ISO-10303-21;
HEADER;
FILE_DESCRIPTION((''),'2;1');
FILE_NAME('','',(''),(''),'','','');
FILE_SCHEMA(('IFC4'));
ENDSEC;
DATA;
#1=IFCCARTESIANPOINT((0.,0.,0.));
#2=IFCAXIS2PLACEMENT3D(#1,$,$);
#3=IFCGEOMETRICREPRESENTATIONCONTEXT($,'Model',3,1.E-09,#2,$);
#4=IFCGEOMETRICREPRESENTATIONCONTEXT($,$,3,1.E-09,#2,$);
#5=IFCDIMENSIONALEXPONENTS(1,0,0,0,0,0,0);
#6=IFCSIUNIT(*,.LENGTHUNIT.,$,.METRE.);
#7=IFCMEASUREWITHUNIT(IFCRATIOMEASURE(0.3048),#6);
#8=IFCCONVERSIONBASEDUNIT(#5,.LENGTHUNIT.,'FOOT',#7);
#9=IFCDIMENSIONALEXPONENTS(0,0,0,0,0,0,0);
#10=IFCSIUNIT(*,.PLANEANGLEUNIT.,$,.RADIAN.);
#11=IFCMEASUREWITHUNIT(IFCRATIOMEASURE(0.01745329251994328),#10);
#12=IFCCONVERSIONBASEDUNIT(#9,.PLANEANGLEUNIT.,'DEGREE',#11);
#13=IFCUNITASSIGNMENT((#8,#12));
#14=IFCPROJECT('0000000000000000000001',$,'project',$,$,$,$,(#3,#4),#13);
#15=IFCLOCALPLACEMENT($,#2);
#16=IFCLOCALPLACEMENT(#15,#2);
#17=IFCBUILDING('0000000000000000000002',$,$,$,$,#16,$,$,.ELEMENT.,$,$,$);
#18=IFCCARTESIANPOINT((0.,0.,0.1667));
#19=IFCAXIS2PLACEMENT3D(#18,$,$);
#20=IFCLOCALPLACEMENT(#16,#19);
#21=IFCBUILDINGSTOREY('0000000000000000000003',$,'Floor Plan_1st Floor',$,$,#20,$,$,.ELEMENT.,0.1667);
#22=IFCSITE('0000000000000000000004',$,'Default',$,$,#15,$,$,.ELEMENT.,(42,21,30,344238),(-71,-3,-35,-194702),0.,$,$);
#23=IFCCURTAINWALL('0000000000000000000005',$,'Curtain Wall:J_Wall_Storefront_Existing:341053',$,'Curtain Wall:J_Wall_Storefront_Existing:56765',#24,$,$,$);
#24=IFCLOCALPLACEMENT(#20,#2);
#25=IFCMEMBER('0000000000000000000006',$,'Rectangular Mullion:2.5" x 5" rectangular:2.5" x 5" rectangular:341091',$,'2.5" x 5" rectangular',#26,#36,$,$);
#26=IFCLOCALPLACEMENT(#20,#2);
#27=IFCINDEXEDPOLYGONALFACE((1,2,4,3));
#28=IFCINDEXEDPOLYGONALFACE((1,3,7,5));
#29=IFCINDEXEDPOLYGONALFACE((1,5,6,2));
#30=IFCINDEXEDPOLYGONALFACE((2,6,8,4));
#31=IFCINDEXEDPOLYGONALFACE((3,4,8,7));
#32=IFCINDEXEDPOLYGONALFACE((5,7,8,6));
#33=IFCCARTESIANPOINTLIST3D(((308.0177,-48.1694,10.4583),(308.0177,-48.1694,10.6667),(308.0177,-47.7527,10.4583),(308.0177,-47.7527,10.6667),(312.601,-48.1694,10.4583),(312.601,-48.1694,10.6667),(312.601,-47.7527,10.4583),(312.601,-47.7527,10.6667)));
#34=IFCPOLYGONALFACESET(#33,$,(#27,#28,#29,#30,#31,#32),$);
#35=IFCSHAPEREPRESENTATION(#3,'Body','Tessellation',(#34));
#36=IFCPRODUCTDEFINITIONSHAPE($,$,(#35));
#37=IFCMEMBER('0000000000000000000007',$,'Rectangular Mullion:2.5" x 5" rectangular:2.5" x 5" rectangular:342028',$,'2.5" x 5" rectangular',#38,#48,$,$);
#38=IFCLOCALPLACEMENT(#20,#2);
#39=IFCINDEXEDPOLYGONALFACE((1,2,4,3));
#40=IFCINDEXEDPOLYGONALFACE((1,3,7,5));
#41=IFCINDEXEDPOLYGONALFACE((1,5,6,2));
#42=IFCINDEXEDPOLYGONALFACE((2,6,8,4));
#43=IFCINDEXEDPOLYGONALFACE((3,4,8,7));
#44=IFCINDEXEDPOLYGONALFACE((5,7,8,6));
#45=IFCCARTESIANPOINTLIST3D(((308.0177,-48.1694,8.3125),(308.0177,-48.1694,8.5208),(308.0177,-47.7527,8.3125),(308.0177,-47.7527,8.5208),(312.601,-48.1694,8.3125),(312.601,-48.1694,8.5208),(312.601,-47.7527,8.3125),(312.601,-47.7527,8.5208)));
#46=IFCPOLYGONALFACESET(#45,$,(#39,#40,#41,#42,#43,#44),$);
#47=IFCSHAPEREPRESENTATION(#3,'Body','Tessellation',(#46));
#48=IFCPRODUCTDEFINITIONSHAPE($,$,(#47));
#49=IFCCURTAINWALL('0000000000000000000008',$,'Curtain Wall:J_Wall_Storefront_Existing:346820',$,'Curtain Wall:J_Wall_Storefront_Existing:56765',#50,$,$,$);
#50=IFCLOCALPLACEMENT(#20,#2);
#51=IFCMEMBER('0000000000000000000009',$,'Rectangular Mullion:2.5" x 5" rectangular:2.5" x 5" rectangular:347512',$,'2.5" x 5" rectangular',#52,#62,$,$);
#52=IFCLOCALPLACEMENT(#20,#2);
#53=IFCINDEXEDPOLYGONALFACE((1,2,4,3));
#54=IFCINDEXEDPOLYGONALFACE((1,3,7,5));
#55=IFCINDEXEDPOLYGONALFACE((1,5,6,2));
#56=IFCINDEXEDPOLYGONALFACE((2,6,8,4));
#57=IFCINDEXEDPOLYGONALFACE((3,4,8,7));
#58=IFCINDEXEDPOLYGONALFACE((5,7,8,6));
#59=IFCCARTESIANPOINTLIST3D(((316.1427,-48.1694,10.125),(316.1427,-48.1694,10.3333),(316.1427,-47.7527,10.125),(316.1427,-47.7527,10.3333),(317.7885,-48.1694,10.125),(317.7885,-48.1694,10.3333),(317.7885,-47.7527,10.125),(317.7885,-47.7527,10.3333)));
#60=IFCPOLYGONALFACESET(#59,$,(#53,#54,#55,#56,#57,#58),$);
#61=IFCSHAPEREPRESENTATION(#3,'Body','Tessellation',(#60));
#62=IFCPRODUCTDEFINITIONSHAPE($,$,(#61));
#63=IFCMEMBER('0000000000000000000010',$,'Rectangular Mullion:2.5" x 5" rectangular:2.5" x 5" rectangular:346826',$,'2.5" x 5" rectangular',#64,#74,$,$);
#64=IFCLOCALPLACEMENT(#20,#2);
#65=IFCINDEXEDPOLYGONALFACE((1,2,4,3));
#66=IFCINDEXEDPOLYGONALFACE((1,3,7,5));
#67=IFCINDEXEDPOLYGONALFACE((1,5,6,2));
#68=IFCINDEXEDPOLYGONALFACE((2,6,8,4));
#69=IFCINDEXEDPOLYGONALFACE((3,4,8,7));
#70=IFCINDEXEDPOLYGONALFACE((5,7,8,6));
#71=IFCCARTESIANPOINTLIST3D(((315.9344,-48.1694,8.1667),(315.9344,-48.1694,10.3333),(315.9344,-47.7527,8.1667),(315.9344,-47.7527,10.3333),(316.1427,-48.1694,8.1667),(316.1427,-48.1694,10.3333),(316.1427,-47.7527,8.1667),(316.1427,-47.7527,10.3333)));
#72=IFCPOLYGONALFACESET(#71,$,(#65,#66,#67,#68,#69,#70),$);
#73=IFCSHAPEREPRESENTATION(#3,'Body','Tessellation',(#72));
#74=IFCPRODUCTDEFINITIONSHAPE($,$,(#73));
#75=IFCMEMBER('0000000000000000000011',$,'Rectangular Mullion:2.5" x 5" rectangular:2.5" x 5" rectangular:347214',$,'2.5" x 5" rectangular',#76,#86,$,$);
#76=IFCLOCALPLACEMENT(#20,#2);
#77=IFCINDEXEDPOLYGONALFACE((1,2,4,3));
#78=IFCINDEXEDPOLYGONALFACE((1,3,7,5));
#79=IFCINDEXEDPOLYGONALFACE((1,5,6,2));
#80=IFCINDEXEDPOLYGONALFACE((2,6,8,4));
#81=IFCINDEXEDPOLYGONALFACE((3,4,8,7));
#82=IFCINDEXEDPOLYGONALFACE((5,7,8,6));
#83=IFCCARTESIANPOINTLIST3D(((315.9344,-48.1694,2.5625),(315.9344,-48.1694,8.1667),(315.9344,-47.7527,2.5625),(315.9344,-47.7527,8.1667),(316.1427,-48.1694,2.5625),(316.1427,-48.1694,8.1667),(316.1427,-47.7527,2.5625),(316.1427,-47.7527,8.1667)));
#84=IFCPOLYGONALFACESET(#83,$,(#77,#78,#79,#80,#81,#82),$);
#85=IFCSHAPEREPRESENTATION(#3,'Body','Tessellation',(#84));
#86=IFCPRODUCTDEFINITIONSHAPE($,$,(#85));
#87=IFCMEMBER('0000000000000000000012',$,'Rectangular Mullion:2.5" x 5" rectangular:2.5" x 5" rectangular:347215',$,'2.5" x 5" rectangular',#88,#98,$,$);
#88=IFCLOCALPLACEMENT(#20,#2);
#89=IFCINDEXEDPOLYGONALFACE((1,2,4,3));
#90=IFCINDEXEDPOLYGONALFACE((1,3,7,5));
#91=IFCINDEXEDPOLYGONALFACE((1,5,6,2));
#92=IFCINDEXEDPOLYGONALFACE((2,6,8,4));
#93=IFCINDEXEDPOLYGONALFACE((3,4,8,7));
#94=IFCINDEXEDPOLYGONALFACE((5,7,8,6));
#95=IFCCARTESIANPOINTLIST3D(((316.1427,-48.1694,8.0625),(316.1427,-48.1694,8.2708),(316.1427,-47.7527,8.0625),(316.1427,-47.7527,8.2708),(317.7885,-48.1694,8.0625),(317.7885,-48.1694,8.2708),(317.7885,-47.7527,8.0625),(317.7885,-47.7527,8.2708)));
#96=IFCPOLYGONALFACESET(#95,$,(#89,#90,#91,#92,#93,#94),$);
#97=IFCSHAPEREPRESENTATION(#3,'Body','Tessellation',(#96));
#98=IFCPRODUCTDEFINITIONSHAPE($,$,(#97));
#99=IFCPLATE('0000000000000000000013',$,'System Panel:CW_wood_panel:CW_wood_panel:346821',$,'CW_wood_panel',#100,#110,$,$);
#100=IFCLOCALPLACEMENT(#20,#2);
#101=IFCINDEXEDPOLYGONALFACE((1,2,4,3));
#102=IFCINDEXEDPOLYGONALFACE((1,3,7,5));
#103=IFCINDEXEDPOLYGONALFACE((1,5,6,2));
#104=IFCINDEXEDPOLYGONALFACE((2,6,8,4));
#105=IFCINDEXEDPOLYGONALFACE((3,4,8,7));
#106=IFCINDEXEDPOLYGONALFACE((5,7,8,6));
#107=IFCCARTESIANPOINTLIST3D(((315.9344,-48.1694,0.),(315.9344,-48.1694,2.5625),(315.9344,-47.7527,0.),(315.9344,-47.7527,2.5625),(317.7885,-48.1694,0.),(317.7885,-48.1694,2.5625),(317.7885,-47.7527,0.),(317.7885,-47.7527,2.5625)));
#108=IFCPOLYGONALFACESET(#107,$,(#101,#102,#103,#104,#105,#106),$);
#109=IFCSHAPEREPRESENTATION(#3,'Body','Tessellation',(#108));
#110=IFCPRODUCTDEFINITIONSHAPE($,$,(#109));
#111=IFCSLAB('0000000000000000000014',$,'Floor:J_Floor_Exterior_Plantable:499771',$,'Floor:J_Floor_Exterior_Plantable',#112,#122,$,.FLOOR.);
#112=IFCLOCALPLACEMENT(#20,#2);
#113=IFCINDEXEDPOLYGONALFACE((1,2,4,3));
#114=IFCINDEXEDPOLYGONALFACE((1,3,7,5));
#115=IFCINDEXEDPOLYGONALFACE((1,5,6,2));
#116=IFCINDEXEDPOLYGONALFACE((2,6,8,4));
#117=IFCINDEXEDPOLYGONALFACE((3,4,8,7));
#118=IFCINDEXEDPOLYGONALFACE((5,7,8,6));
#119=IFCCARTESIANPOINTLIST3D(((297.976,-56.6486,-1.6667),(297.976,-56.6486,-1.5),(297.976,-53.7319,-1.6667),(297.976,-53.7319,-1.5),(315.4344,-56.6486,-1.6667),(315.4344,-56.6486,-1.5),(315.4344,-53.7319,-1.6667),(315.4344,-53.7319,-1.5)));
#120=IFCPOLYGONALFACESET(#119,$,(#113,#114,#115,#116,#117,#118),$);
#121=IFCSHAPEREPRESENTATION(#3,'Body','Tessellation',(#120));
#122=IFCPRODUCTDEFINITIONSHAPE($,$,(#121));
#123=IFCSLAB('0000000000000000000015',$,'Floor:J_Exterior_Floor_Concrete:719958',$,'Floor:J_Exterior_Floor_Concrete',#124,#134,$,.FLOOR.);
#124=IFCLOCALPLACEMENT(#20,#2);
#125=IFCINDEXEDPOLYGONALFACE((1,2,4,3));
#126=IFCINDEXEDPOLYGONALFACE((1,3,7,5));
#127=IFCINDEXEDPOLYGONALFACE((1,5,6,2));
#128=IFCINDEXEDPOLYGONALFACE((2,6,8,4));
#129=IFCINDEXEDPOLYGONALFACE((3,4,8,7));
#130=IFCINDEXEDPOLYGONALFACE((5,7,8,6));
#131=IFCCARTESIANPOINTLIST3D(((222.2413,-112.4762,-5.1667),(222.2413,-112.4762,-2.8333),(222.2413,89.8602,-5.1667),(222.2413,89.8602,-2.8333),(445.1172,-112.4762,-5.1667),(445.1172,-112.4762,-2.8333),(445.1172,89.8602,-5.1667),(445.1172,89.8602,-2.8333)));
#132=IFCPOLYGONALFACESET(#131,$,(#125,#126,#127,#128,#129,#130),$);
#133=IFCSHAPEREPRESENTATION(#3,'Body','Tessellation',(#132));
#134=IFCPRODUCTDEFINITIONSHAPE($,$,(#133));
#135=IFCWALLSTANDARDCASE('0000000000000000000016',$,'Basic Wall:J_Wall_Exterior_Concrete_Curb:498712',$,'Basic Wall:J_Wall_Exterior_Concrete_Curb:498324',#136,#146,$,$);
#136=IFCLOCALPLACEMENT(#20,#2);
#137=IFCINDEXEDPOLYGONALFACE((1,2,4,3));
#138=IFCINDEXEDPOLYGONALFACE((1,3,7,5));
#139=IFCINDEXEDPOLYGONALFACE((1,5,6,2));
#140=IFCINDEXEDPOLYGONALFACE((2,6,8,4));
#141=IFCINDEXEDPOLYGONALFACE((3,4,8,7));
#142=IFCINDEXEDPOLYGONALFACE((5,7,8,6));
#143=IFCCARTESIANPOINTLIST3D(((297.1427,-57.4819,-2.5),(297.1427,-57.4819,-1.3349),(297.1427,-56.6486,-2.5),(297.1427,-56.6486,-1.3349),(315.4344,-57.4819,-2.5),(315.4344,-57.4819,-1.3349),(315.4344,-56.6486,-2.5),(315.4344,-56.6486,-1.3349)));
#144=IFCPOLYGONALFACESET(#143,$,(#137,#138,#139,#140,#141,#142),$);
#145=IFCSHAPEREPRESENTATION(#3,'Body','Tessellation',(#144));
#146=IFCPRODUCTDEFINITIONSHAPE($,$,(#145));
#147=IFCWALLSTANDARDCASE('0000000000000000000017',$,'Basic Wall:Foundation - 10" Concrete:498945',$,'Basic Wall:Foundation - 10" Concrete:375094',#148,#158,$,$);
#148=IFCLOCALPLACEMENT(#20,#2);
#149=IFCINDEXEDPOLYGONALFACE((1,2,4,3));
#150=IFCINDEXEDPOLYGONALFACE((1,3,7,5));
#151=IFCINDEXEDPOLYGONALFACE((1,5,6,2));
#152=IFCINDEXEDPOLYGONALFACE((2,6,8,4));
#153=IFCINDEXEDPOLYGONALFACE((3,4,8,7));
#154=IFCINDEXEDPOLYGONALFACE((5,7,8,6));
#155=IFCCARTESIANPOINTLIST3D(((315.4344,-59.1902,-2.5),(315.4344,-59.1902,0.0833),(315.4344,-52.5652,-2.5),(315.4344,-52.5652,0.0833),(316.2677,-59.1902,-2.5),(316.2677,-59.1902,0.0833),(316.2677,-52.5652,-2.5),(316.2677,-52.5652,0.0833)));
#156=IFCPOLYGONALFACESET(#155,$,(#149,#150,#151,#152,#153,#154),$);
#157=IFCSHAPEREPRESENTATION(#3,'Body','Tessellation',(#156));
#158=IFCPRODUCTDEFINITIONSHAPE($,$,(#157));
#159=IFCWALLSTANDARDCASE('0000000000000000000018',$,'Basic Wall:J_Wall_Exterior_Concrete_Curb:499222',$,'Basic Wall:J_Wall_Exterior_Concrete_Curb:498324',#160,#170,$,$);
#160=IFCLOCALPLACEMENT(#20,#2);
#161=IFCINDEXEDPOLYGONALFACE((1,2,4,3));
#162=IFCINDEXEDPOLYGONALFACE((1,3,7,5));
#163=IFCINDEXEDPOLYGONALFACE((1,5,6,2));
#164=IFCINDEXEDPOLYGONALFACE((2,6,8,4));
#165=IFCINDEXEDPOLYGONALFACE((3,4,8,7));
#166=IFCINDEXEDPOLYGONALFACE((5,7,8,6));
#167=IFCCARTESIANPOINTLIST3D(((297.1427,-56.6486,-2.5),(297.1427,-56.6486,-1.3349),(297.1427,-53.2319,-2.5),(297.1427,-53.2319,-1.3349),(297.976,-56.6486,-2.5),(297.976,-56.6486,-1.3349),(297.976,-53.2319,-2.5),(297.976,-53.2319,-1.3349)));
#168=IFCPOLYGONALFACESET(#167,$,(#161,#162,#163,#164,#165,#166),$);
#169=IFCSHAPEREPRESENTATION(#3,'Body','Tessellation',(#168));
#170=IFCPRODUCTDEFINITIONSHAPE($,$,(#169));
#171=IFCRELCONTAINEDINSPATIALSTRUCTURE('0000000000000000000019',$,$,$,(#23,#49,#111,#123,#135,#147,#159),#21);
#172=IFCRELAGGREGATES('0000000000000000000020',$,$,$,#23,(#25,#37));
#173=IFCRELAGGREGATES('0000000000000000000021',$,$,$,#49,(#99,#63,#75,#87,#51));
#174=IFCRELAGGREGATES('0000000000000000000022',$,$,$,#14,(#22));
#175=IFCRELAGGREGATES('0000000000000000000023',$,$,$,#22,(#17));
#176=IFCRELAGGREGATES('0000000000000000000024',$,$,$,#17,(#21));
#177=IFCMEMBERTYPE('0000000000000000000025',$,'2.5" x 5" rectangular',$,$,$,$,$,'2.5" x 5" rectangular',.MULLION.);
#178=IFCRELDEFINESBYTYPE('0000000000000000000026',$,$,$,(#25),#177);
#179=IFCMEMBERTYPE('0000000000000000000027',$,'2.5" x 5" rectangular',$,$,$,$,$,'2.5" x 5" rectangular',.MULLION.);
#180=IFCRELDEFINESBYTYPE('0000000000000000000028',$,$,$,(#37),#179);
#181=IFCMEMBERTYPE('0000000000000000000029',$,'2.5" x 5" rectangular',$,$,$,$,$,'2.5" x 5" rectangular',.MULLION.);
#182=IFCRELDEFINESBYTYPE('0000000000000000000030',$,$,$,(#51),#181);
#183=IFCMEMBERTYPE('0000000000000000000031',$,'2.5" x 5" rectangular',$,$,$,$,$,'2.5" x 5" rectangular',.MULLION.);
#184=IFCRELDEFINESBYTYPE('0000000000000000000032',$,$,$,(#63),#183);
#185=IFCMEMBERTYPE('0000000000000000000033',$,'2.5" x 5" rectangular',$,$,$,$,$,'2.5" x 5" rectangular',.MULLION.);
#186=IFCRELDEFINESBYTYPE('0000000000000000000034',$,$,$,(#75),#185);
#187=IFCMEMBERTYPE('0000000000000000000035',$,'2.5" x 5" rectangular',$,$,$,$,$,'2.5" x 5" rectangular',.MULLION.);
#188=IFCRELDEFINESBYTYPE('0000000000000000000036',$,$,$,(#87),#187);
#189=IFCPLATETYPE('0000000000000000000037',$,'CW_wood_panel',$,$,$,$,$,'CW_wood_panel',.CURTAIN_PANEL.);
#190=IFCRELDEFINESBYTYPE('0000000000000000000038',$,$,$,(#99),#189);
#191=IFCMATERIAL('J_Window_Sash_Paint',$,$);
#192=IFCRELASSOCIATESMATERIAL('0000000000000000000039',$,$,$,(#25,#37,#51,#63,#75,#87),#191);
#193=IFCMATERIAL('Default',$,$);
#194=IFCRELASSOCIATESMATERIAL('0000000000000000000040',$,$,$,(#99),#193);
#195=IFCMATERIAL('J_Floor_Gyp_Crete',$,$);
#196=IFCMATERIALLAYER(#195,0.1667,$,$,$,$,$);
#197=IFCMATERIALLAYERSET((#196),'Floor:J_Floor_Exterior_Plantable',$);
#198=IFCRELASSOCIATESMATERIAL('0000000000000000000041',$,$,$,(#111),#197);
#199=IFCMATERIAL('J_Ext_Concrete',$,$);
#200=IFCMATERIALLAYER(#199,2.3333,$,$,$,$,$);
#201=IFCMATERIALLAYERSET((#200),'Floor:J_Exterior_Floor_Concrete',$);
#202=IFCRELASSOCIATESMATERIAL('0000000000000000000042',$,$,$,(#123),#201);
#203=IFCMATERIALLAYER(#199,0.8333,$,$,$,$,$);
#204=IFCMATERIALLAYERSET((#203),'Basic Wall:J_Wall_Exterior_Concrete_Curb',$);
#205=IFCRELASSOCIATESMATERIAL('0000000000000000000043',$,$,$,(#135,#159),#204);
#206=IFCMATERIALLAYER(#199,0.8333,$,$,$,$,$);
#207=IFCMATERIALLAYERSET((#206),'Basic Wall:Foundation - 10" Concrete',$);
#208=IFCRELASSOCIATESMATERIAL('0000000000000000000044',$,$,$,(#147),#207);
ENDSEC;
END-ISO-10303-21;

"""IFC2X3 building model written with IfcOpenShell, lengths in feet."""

from ifc_helpers import new_model, entity, si_unit, converted_unit, frame, frame_2d, origin, origin_2d_with_axis, place, context, project, spatial, rectangle, extrude, source, transform, mapped, material, layer, layer_set, layer_usage, type_object, type_shapes, element, aggregate, save


model = new_model("IFC2X3")

# Units and contexts
model_context = context("Model", 3, precision=1e-09, world=origin())
context_of_model = context(None, 3, precision=1e-09, world=origin())
ifc_project = project(units=[converted_unit("LENGTHUNIT", "FOOT", entity("IfcRatioMeasure", 0.3048), si_unit("LENGTHUNIT", "METRE"), dimensions=[1, 0, 0, 0, 0, 0, 0]), converted_unit("PLANEANGLEUNIT", "DEGREE", entity("IfcRatioMeasure", 0.01745329251994328), si_unit("PLANEANGLEUNIT", "RADIAN"), dimensions=[0, 0, 0, 0, 0, 0, 0])], contexts=[model_context, context_of_model])

# Site, building, storey
site_placement = place(None, origin())
site = spatial("IfcSite", under=ifc_project, at=site_placement, Name="Default", CompositionType="ELEMENT", RefLatitude=(42, 21, 30, 344238), RefLongitude=(-71, -3, -35, -194702), RefElevation=0.0)
building_placement = place(site_placement, origin())
building = spatial("IfcBuilding", under=site, at=building_placement, CompositionType="ELEMENT")
storey_placement = place(building_placement, frame((0.0, 0.0, 0.1667)))
storey = spatial("IfcBuildingStorey", under=building, at=storey_placement, Name="Floor Plan_1st Floor", CompositionType="ELEMENT", Elevation=0.1667)

# Curtain walls, members
curtain_wall_1_placement = place(storey_placement, origin())
curtain_wall_1 = element("IfcCurtainWall", 1, at=curtain_wall_1_placement, inside=storey, Name="Curtain Wall:J_Wall_Storefront_Existing:341053", ObjectType="Curtain Wall:J_Wall_Storefront_Existing:56765")
ifc_material_1 = material(Name="J_Window_Sash_Paint")
member_type_1 = type_object("IfcMemberType", Name="2.5\" x 5\" rectangular", ElementType="2.5\" x 5\" rectangular", PredefinedType="MULLION")
shared_shape_1 = source(origin(), model_context, "Body", "SweptSolid", [
    extrude(rectangle(XDim=0.2083, YDim=0.4167, at=origin_2d_with_axis()), frame((-0.1042, 0.0, -4.5833), z_axis=(0.0, 0.0, 1.0), x_axis=(-1.0, 0.0, 0.0)), (0.0, 0.0, 1.0), 4.5833),
])
type_shapes(member_type_1, [shared_shape_1])
member_1_placement = place(storey_placement, frame((312.601, -47.9611, 10.6667), z_axis=(1.0, 0.0, 0.0), x_axis=(0.0, 0.0, 1.0)))
member_1 = element("IfcMember", 2, at=member_1_placement, type_object=member_type_1, material=ifc_material_1, Name="Rectangular Mullion:2.5\" x 5\" rectangular:2.5\" x 5\" rectangular:341091", ObjectType="2.5\" x 5\" rectangular", context=model_context, shape_type="MappedRepresentation", body=[
    mapped(shared_shape_1, transform((0.0, 0.0, 0.0), scale=1.0)),
])
member_type_2 = type_object("IfcMemberType", Name="2.5\" x 5\" rectangular", ElementType="2.5\" x 5\" rectangular", PredefinedType="MULLION")
shared_shape_2 = source(origin(), model_context, "Body", "SweptSolid", [
    extrude(rectangle(XDim=0.2083, YDim=0.4167, at=origin_2d_with_axis()), frame((0.0, 0.0, -4.5833), z_axis=(0.0, 0.0, 1.0), x_axis=(-1.0, 0.0, 0.0)), (0.0, 0.0, 1.0), 4.5833),
])
type_shapes(member_type_2, [shared_shape_2])
member_2_placement = place(storey_placement, frame((312.601, -47.9611, 8.4167), z_axis=(1.0, 0.0, 0.0), x_axis=(0.0, 0.0, 1.0)))
member_2 = element("IfcMember", 3, at=member_2_placement, type_object=member_type_2, material=ifc_material_1, Name="Rectangular Mullion:2.5\" x 5\" rectangular:2.5\" x 5\" rectangular:342028", ObjectType="2.5\" x 5\" rectangular", context=model_context, shape_type="MappedRepresentation", body=[
    mapped(shared_shape_2, transform((0.0, 0.0, 0.0), scale=1.0)),
])
curtain_wall_2_placement = place(storey_placement, origin())
curtain_wall_2 = element("IfcCurtainWall", 4, at=curtain_wall_2_placement, inside=storey, Name="Curtain Wall:J_Wall_Storefront_Existing:346820", ObjectType="Curtain Wall:J_Wall_Storefront_Existing:56765")
member_type_3 = type_object("IfcMemberType", Name="2.5\" x 5\" rectangular", ElementType="2.5\" x 5\" rectangular", PredefinedType="MULLION")
shared_shape_3 = source(origin(), model_context, "Body", "SweptSolid", [
    extrude(rectangle(XDim=0.2083, YDim=0.4167, at=origin_2d_with_axis()), frame((-0.1042, 0.0, -1.6458), z_axis=(0.0, 0.0, 1.0), x_axis=(-1.0, 0.0, 0.0)), (0.0, 0.0, 1.0), 1.6458),
])
type_shapes(member_type_3, [shared_shape_3])
member_3_placement = place(storey_placement, frame((317.7885, -47.9611, 10.3333), z_axis=(1.0, 0.0, 0.0), x_axis=(0.0, 0.0, 1.0)))
member_3 = element("IfcMember", 5, at=member_3_placement, type_object=member_type_3, material=ifc_material_1, Name="Rectangular Mullion:2.5\" x 5\" rectangular:2.5\" x 5\" rectangular:347512", ObjectType="2.5\" x 5\" rectangular", context=model_context, shape_type="MappedRepresentation", body=[
    mapped(shared_shape_3, transform((0.0, 0.0, 0.0), scale=1.0)),
])
member_type_4 = type_object("IfcMemberType", Name="2.5\" x 5\" rectangular", ElementType="2.5\" x 5\" rectangular", PredefinedType="MULLION")
shared_shape_4 = source(origin(), model_context, "Body", "SweptSolid", [
    extrude(rectangle(XDim=0.2083, YDim=0.4167, at=origin_2d_with_axis()), frame((-0.1042, 0.0, -2.1667), z_axis=(0.0, 0.0, 1.0), x_axis=(-1.0, 0.0, 0.0)), (0.0, 0.0, 1.0), 2.1667),
])
type_shapes(member_type_4, [shared_shape_4])
member_4_placement = place(storey_placement, frame((315.9344, -47.9611, 10.3333), z_axis=(0.0, 0.0, 1.0), x_axis=(-1.0, 0.0, 0.0)))
member_4 = element("IfcMember", 6, at=member_4_placement, type_object=member_type_4, material=ifc_material_1, Name="Rectangular Mullion:2.5\" x 5\" rectangular:2.5\" x 5\" rectangular:346826", ObjectType="2.5\" x 5\" rectangular", context=model_context, shape_type="MappedRepresentation", body=[
    mapped(shared_shape_4, transform((0.0, 0.0, 0.0), scale=1.0)),
])
member_type_5 = type_object("IfcMemberType", Name="2.5\" x 5\" rectangular", ElementType="2.5\" x 5\" rectangular", PredefinedType="MULLION")
shared_shape_5 = source(origin(), model_context, "Body", "SweptSolid", [
    extrude(rectangle(XDim=0.2083, YDim=0.4167, at=origin_2d_with_axis()), frame((-0.1042, 0.0, -5.6042), z_axis=(0.0, 0.0, 1.0), x_axis=(-1.0, 0.0, 0.0)), (0.0, 0.0, 1.0), 5.6042),
])
type_shapes(member_type_5, [shared_shape_5])
member_5_placement = place(storey_placement, frame((315.9344, -47.9611, 8.1667), z_axis=(0.0, 0.0, 1.0), x_axis=(-1.0, 0.0, 0.0)))
member_5 = element("IfcMember", 7, at=member_5_placement, type_object=member_type_5, material=ifc_material_1, Name="Rectangular Mullion:2.5\" x 5\" rectangular:2.5\" x 5\" rectangular:347214", ObjectType="2.5\" x 5\" rectangular", context=model_context, shape_type="MappedRepresentation", body=[
    mapped(shared_shape_5, transform((0.0, 0.0, 0.0), scale=1.0)),
])
member_type_6 = type_object("IfcMemberType", Name="2.5\" x 5\" rectangular", ElementType="2.5\" x 5\" rectangular", PredefinedType="MULLION")
shared_shape_6 = source(origin(), model_context, "Body", "SweptSolid", [
    extrude(rectangle(XDim=0.2083, YDim=0.4167, at=origin_2d_with_axis()), frame((0.0, 0.0, -1.6458), z_axis=(0.0, 0.0, 1.0), x_axis=(-1.0, 0.0, 0.0)), (0.0, 0.0, 1.0), 1.6458),
])
type_shapes(member_type_6, [shared_shape_6])
member_6_placement = place(storey_placement, frame((317.7885, -47.9611, 8.1667), z_axis=(1.0, 0.0, 0.0), x_axis=(0.0, 0.0, 1.0)))
member_6 = element("IfcMember", 8, at=member_6_placement, type_object=member_type_6, material=ifc_material_1, Name="Rectangular Mullion:2.5\" x 5\" rectangular:2.5\" x 5\" rectangular:347215", ObjectType="2.5\" x 5\" rectangular", context=model_context, shape_type="MappedRepresentation", body=[
    mapped(shared_shape_6, transform((0.0, 0.0, 0.0), scale=1.0)),
])

# Plate
aggregate(curtain_wall_1, [member_1, member_2])
ifc_material_2 = material(Name="Default")
plate_type_1 = type_object("IfcPlateType", Name="CW_wood_panel", ElementType="CW_wood_panel", PredefinedType="CURTAIN_PANEL")
shared_shape_7 = source(origin(), model_context, "Body", "SweptSolid", [
    extrude(rectangle(XDim=0.4167, YDim=1.8542, at=origin_2d_with_axis()), frame((0.0, 0.0, 0.0), z_axis=(0.0, 0.0, 1.0), x_axis=(0.0, 1.0, 0.0)), (0.0, 0.0, 1.0), 2.5625),
])
type_shapes(plate_type_1, [shared_shape_7])
plate_1_placement = place(storey_placement, frame((316.8614, -47.9611, 0.0)))
plate_1 = element("IfcPlate", 9, at=plate_1_placement, type_object=plate_type_1, material=ifc_material_2, Name="System Panel:CW_wood_panel:CW_wood_panel:346821", ObjectType="CW_wood_panel", context=model_context, shape_type="MappedRepresentation", body=[
    mapped(shared_shape_7, transform((0.0, 0.0, 0.0), scale=1.0)),
])
aggregate(curtain_wall_2, [plate_1, member_4, member_5, member_6, member_3])

# Slabs
ifc_material_3 = material(Name="J_Ext_Concrete")
ifc_layer_1 = layer(ifc_material_3, 2.3333)
ifc_layer_set_1 = layer_set([ifc_layer_1], Name="Floor:J_Exterior_Floor_Concrete")
ifc_material_4 = material(Name="J_Floor_Gyp_Crete")
ifc_layer_2 = layer(ifc_material_4, 0.1667)
ifc_layer_set_2 = layer_set([ifc_layer_2], Name="Floor:J_Floor_Exterior_Plantable")
ifc_layer_usage_1 = layer_usage(ifc_layer_set_2, "AXIS3", "POSITIVE", 0.0)
slab_1_placement = place(storey_placement, frame((297.976, -56.6486, -1.6667)))
element("IfcSlab", 10, at=slab_1_placement, inside=storey, material=ifc_layer_usage_1, Name="Floor:J_Floor_Exterior_Plantable:499771", ObjectType="Floor:J_Floor_Exterior_Plantable", PredefinedType="FLOOR", context=model_context, shape_type="SweptSolid", body=[
    extrude(rectangle(XDim=2.9167, YDim=17.4583, at=frame_2d((0.0, 0.0), x_axis=(0.0, -1.0))), frame((8.7292, 1.4583, 0.1667), z_axis=(0.0, 0.0, -1.0), x_axis=(-1.0, 0.0, 0.0)), (0.0, 0.0, 1.0), 0.1667),
])
ifc_layer_usage_2 = layer_usage(ifc_layer_set_1, "AXIS3", "POSITIVE", 0.0)
slab_2_placement = place(storey_placement, frame((222.2413, -112.4762, -5.1667)))
element("IfcSlab", 11, at=slab_2_placement, inside=storey, material=ifc_layer_usage_2, Name="Floor:J_Exterior_Floor_Concrete:719958", ObjectType="Floor:J_Exterior_Floor_Concrete", PredefinedType="FLOOR", context=model_context, shape_type="SweptSolid", body=[
    extrude(rectangle(XDim=202.3364, YDim=222.8759, at=frame_2d((0.0, 0.0), x_axis=(0.0, -1.0))), frame((111.438, 101.1682, 2.3333), z_axis=(0.0, 0.0, -1.0), x_axis=(-1.0, 0.0, 0.0)), (0.0, 0.0, 1.0), 2.3333),
])

# Walls
ifc_layer_3 = layer(ifc_material_3, 0.8333)
ifc_layer_set_3 = layer_set([ifc_layer_3], Name="Basic Wall:J_Wall_Exterior_Concrete_Curb")
ifc_layer_usage_3 = layer_usage(ifc_layer_set_3, "AXIS2", "POSITIVE", -0.4167)
wall_1_placement = place(storey_placement, frame((297.1427, -57.0652, -2.5)))
element("IfcWallStandardCase", 12, at=wall_1_placement, inside=storey, material=ifc_layer_usage_3, Name="Basic Wall:J_Wall_Exterior_Concrete_Curb:498712", ObjectType="Basic Wall:J_Wall_Exterior_Concrete_Curb:498324", context=model_context, shape_type="SweptSolid", body=[
    extrude(rectangle(XDim=18.2917, YDim=0.8333, at=frame_2d((9.1458, 0.0), x_axis=(-1.0, 0.0))), origin(), (0.0, 0.0, 1.0), 1.1651),
])
ifc_layer_4 = layer(ifc_material_3, 0.8333)
ifc_layer_set_4 = layer_set([ifc_layer_4], Name="Basic Wall:Foundation - 10\" Concrete")
ifc_layer_usage_4 = layer_usage(ifc_layer_set_4, "AXIS2", "NEGATIVE", 0.4167)
wall_2_placement = place(storey_placement, frame((315.851, -52.5652, -2.5), z_axis=(0.0, 0.0, 1.0), x_axis=(0.0, -1.0, 0.0)))
element("IfcWallStandardCase", 13, at=wall_2_placement, inside=storey, material=ifc_layer_usage_4, Name="Basic Wall:Foundation - 10\" Concrete:498945", ObjectType="Basic Wall:Foundation - 10\" Concrete:375094", context=model_context, shape_type="SweptSolid", body=[
    extrude(rectangle(XDim=6.625, YDim=0.8333, at=frame_2d((3.3125, 0.0), x_axis=(-1.0, 0.0))), origin(), (0.0, 0.0, 1.0), 2.5833),
])
ifc_layer_usage_5 = layer_usage(ifc_layer_set_3, "AXIS2", "NEGATIVE", 0.4167)
wall_3_placement = place(storey_placement, frame((297.5594, -53.2319, -2.5), z_axis=(0.0, 0.0, 1.0), x_axis=(0.0, -1.0, 0.0)))
element("IfcWallStandardCase", 14, at=wall_3_placement, inside=storey, material=ifc_layer_usage_5, Name="Basic Wall:J_Wall_Exterior_Concrete_Curb:499222", ObjectType="Basic Wall:J_Wall_Exterior_Concrete_Curb:498324", context=model_context, shape_type="SweptSolid", body=[
    extrude(rectangle(XDim=3.4167, YDim=0.8333, at=frame_2d((1.7083, 0.0), x_axis=(-1.0, 0.0))), origin(), (0.0, 0.0, 1.0), 1.1651),
])

save(model, "model.ifc")
